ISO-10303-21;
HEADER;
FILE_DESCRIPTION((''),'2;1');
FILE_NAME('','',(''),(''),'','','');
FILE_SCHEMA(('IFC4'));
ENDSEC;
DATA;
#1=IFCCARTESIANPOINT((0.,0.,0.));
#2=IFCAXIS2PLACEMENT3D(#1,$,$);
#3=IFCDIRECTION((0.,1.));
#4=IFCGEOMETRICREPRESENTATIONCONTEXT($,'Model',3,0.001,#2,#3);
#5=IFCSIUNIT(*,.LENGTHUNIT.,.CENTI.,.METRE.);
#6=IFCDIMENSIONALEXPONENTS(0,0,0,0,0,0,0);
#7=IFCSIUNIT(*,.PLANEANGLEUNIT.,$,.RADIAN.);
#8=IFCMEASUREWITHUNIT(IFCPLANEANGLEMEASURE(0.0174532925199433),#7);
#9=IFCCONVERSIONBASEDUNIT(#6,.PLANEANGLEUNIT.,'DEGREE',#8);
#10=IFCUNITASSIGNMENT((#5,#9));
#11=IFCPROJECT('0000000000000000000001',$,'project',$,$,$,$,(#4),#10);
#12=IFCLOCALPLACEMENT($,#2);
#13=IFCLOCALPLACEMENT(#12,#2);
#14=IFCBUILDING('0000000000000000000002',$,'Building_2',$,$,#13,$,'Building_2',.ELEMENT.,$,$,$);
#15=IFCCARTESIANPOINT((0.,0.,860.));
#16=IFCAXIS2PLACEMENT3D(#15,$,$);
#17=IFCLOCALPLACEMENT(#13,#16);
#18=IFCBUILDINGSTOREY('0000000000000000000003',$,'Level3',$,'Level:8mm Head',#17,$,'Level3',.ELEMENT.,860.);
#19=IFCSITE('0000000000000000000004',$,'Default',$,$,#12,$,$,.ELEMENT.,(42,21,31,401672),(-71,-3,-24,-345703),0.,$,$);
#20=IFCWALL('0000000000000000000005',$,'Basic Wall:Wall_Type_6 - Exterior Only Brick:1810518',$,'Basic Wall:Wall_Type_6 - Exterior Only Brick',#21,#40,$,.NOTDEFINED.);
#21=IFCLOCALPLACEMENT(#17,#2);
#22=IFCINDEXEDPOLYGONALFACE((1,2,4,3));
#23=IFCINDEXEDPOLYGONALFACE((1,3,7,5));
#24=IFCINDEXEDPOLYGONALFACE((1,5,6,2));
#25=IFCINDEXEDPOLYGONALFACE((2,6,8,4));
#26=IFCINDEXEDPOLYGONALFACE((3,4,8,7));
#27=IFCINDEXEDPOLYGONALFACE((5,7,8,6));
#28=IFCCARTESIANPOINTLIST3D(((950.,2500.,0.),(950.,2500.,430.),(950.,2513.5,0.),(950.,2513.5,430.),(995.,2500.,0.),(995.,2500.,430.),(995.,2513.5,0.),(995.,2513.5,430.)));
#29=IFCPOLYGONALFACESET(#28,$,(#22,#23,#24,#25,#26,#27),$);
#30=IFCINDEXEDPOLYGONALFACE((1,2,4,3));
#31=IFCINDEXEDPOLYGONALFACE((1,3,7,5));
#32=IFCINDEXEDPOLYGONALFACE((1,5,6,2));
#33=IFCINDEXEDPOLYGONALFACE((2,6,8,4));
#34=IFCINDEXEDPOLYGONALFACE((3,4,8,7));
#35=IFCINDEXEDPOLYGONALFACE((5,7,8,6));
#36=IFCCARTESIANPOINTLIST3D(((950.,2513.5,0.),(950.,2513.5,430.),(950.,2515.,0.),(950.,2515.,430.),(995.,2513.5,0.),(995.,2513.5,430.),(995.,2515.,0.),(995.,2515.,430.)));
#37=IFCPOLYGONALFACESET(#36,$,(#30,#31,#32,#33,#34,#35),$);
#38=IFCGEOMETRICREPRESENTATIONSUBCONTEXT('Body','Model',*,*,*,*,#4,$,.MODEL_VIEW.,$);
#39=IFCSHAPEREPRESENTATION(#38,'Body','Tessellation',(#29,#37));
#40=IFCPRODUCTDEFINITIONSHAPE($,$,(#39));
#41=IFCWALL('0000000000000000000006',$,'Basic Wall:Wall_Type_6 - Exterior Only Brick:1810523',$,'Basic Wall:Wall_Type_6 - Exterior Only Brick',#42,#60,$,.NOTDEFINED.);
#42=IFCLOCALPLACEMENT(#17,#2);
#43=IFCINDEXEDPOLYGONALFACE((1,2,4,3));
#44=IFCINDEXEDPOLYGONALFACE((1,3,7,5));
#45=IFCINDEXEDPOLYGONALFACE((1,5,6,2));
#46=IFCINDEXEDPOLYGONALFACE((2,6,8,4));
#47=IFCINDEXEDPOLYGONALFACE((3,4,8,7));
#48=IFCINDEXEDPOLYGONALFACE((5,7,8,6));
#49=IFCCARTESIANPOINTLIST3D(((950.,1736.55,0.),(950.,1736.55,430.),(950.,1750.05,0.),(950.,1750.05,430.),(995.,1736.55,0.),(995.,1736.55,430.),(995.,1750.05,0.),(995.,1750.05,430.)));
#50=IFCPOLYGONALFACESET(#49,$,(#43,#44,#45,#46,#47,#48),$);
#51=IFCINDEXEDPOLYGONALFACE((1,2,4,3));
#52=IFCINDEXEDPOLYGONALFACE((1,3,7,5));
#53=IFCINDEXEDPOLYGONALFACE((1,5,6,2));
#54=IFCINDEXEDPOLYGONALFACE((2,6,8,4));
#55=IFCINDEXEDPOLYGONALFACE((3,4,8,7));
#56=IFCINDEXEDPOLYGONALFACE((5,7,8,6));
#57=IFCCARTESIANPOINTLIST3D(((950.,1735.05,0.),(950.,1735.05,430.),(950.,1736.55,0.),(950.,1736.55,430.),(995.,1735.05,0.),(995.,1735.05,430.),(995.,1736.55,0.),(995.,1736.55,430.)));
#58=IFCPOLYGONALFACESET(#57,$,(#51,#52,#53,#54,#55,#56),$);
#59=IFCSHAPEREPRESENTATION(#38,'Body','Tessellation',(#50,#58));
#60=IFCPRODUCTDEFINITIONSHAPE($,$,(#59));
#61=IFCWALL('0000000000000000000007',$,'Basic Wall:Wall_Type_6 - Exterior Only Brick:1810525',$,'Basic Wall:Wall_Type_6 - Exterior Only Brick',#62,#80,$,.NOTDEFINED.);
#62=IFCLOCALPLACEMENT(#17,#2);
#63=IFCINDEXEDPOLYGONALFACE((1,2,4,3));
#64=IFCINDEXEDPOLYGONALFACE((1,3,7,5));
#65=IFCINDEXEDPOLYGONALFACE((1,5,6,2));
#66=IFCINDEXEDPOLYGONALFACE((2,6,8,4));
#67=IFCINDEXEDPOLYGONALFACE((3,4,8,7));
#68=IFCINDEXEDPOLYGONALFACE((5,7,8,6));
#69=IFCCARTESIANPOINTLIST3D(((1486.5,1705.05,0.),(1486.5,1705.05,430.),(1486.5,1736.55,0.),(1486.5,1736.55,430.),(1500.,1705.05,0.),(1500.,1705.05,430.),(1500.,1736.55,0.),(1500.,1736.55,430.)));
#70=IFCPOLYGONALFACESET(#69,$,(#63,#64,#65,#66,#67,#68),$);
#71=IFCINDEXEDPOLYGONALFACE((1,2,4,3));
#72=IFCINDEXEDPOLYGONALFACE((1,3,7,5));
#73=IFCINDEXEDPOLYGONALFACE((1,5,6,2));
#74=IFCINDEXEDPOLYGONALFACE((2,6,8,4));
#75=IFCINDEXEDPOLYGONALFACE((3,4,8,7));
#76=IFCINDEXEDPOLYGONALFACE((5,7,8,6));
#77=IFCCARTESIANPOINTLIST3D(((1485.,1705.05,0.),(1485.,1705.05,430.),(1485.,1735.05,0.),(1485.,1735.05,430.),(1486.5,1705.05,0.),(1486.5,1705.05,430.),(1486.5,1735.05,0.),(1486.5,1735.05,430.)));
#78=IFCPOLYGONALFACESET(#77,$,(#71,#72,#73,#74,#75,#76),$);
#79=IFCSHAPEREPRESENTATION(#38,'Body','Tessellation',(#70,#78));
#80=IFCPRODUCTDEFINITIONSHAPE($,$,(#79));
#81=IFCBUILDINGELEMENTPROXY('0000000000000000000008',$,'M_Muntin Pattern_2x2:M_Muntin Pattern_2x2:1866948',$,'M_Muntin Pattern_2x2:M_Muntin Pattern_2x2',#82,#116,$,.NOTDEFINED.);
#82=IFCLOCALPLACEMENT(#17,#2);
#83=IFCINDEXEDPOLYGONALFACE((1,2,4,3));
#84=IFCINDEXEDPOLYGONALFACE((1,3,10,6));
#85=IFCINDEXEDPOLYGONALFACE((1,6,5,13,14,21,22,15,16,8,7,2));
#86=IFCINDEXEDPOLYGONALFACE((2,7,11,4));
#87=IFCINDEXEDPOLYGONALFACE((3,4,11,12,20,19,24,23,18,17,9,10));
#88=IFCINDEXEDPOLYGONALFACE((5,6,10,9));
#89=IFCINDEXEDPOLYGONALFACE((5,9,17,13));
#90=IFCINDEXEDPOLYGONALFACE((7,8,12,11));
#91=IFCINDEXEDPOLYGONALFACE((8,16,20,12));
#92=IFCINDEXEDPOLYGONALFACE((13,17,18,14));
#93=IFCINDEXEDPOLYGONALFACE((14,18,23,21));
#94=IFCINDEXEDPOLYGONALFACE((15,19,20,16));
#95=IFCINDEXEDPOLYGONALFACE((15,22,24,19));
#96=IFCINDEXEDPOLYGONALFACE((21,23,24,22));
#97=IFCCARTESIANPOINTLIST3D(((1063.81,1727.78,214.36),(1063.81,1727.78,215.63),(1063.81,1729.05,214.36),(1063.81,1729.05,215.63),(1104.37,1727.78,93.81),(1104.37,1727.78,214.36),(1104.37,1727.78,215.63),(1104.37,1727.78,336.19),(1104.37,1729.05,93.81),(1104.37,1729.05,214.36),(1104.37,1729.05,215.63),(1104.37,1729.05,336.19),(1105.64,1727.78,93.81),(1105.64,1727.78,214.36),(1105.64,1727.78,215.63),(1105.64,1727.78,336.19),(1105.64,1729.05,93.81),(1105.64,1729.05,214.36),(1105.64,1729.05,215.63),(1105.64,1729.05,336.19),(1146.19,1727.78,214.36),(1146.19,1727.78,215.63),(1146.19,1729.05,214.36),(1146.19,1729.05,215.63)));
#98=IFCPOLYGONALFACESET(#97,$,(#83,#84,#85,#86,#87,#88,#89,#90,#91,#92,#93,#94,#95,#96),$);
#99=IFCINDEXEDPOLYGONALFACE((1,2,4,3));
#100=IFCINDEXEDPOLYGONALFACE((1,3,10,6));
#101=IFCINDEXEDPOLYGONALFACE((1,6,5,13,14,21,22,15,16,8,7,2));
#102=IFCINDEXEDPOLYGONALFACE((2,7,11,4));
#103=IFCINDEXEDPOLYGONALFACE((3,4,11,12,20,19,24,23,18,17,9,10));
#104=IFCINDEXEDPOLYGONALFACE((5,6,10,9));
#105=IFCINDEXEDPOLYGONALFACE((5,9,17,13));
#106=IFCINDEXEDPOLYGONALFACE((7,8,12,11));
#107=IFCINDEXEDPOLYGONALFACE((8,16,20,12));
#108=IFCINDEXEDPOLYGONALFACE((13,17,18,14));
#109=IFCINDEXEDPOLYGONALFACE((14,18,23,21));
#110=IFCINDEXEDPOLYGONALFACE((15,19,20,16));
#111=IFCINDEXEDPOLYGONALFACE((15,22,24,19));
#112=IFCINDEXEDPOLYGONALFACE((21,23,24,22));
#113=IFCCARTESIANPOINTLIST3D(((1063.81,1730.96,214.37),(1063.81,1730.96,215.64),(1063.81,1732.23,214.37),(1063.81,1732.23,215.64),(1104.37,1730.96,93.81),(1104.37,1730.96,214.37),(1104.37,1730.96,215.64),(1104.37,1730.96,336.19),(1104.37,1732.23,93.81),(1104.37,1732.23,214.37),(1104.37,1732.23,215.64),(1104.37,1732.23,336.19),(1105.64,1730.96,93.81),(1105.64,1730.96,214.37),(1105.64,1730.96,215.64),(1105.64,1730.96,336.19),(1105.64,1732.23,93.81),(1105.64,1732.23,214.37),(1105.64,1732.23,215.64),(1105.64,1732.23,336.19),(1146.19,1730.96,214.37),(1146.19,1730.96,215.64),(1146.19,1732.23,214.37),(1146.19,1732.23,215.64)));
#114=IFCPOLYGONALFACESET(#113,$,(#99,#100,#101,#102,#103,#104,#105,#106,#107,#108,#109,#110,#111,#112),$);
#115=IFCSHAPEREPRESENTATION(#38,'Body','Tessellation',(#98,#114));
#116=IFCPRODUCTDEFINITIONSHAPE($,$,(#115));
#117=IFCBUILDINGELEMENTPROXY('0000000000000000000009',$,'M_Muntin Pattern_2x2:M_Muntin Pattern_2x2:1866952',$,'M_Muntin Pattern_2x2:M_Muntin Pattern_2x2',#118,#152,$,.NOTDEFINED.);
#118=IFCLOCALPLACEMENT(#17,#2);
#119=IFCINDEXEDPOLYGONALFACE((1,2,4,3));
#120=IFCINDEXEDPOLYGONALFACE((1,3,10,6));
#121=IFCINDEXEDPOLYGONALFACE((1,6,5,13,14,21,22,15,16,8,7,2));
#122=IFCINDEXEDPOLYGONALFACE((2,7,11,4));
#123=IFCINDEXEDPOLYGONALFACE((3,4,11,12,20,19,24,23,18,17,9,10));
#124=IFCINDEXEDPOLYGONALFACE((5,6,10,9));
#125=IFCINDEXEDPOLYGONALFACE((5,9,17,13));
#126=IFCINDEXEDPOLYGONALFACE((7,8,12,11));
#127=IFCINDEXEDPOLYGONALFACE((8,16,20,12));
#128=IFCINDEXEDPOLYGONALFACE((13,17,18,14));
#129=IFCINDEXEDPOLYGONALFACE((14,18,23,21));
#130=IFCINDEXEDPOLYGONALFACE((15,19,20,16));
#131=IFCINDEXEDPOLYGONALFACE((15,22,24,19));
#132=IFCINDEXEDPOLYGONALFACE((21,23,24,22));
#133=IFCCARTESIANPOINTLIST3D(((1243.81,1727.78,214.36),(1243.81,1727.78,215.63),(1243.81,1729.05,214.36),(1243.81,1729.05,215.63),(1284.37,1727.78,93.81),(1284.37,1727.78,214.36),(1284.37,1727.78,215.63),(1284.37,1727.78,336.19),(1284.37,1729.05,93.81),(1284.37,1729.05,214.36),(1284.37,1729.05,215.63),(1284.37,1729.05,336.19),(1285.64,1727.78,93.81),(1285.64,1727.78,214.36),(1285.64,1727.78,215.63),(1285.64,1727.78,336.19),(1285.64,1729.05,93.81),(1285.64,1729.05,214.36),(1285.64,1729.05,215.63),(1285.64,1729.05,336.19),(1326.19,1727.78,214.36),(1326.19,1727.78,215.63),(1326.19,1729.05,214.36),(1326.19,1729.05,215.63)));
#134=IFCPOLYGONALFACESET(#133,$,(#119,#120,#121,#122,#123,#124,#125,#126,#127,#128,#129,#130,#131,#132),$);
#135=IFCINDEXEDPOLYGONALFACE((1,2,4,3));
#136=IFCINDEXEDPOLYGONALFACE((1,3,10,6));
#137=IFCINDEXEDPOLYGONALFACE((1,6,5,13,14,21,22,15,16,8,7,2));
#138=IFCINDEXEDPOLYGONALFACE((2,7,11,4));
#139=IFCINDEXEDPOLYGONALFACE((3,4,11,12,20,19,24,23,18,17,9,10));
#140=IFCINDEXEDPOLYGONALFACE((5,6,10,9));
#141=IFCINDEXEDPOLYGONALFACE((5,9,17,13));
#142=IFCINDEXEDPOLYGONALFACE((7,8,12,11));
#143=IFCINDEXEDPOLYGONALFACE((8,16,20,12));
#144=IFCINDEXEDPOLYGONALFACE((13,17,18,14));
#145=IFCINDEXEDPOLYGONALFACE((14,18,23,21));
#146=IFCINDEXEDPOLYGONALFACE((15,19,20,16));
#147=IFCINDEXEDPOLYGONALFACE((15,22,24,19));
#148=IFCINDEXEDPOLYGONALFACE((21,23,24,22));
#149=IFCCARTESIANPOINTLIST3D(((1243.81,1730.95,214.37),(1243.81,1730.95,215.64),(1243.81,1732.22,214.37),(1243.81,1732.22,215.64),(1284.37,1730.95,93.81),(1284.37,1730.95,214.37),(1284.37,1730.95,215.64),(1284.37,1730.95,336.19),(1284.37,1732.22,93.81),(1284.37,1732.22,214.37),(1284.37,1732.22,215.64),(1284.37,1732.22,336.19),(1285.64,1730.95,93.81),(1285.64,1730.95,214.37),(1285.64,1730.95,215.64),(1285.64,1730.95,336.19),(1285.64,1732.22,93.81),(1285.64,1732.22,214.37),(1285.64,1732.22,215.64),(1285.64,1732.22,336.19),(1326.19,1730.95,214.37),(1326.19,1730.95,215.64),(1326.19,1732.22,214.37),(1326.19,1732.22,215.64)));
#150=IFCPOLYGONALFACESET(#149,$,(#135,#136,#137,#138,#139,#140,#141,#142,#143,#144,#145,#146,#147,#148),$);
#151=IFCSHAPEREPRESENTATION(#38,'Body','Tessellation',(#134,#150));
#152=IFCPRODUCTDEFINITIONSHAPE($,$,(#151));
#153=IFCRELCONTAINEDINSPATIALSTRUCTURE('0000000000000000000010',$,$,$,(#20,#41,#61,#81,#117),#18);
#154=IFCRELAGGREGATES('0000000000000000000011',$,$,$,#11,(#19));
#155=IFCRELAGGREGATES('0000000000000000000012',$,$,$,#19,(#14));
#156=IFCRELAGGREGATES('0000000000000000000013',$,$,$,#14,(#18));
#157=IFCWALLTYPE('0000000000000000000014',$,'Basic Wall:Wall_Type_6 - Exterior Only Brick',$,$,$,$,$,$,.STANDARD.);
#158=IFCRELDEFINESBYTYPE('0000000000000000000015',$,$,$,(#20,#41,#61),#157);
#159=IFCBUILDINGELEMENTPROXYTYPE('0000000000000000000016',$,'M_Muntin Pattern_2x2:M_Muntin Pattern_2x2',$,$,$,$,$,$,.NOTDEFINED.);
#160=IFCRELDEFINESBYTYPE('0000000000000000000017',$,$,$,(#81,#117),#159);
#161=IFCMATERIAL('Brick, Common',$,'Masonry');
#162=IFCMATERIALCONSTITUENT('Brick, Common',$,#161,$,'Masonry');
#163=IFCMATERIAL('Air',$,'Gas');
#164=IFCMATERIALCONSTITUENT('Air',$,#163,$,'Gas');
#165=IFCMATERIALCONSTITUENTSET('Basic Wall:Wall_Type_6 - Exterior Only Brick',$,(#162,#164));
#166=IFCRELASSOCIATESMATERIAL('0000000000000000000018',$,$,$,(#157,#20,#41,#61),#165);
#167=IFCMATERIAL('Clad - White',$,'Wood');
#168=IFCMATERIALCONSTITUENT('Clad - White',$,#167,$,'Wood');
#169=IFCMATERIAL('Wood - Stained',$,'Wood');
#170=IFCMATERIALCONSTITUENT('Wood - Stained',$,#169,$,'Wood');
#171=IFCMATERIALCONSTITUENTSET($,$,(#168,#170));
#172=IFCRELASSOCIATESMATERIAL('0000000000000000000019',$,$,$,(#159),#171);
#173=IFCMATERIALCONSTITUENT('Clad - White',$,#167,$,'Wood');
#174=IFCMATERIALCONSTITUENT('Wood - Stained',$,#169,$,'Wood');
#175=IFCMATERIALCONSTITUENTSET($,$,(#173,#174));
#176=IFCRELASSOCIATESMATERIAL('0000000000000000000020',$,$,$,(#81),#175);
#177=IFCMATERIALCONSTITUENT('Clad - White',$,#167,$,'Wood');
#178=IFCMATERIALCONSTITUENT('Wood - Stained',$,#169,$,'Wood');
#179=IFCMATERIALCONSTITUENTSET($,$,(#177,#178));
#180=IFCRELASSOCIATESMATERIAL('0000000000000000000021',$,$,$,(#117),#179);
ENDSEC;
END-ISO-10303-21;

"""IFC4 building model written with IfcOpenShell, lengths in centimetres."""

from ifc_helpers import new_model, entity, si_unit, converted_unit, direction, frame, origin, place, context, subcontext, project, spatial, indexed_curve, outline, extrude, source, transform, mapped, material, constituent, constituent_set, type_object, type_shapes, element, save


model = new_model("IFC4")

# Units and contexts
model_context = context("Model", 3, precision=0.001, world=origin(), true_north=direction((0.0, 1.0)))
body_context = subcontext(model_context, "Body", "Model", "MODEL_VIEW")
ifc_project = project(units=[si_unit("LENGTHUNIT", "METRE", prefix="CENTI"), converted_unit("PLANEANGLEUNIT", "DEGREE", entity("IfcPlaneAngleMeasure", 0.0174532925199433), si_unit("PLANEANGLEUNIT", "RADIAN"), dimensions=[0, 0, 0, 0, 0, 0, 0])], contexts=[model_context])

# Site, building, storey
site_placement = place(None, origin())
site = spatial("IfcSite", under=ifc_project, at=site_placement, Name="Default", CompositionType="ELEMENT", RefLatitude=(42, 21, 31, 401672), RefLongitude=(-71, -3, -24, -345703), RefElevation=0.0)
building_placement = place(site_placement, origin())
building = spatial("IfcBuilding", under=site, at=building_placement, Name="Building_2", LongName="Building_2", CompositionType="ELEMENT")
storey_placement = place(building_placement, frame((0.0, 0.0, 860.0)))
storey = spatial("IfcBuildingStorey", under=building, at=storey_placement, Name="Level3", ObjectType="Level:8mm Head", LongName="Level3", CompositionType="ELEMENT", Elevation=860.0)

# Shared definitions
ifc_material_1 = material(Name="Brick, Common", Category="Masonry")
ifc_material_2 = material(Name="Air", Category="Gas")

# Walls
ifc_constituent_1 = constituent(ifc_material_1, Name="Brick, Common", Category="Masonry")
ifc_constituent_2 = constituent(ifc_material_2, Name="Air", Category="Gas")
ifc_constituent_set_1 = constituent_set(constituents=[ifc_constituent_1, ifc_constituent_2], Name="Basic Wall:Wall_Type_6 - Exterior Only Brick")
wall_type_1 = type_object("IfcWallType", Name="Basic Wall:Wall_Type_6 - Exterior Only Brick", PredefinedType="STANDARD", material=ifc_constituent_set_1)
wall_1_placement = place(storey_placement, frame((995.0, 2507.5, 0.0), z_axis=(0.0, 0.0, 1.0), x_axis=(-1.0, 0.0, 0.0)))
element("IfcWall", 1, at=wall_1_placement, inside=storey, type_object=wall_type_1, material=ifc_constituent_set_1, Name="Basic Wall:Wall_Type_6 - Exterior Only Brick:1810518", ObjectType="Basic Wall:Wall_Type_6 - Exterior Only Brick", PredefinedType="NOTDEFINED", context=body_context, shape_type="SweptSolid", body=[
    extrude(outline(indexed_curve([(-6.75, -22.5), (6.75, -22.5), (6.75, 22.5), (-6.75, 22.5), (-6.75, -22.5)], self_intersect=False)), frame((22.5, 0.75, 0.0), z_axis=(0.0, 0.0, 1.0), x_axis=(0.0, -1.0, 0.0)), (0.0, 0.0, 1.0), 430.0),
    extrude(outline(indexed_curve([(-0.75, -22.5), (0.75, -22.5), (0.75, 22.5), (-0.75, 22.5), (-0.75, -22.5)], self_intersect=False)), frame((22.5, -6.75, 0.0), z_axis=(0.0, 0.0, 1.0), x_axis=(0.0, 1.0, 0.0)), (0.0, 0.0, 1.0), 430.0),
])
wall_2_placement = place(storey_placement, frame((950.0, 1742.55, 0.0)))
element("IfcWall", 2, at=wall_2_placement, inside=storey, type_object=wall_type_1, material=ifc_constituent_set_1, Name="Basic Wall:Wall_Type_6 - Exterior Only Brick:1810523", ObjectType="Basic Wall:Wall_Type_6 - Exterior Only Brick", PredefinedType="NOTDEFINED", context=body_context, shape_type="SweptSolid", body=[
    extrude(outline(indexed_curve([(-6.75, -22.5), (6.75, -22.5), (6.75, 22.5), (-6.75, 22.5), (-6.75, -22.5)], self_intersect=False)), frame((22.5, 0.75, 0.0), z_axis=(0.0, 0.0, 1.0), x_axis=(0.0, -1.0, 0.0)), (0.0, 0.0, 1.0), 430.0),
    extrude(outline(indexed_curve([(-0.75, -22.5), (0.75, -22.5), (0.75, 22.5), (-0.75, 22.5), (-0.75, -22.5)], self_intersect=False)), frame((22.5, -6.75, 0.0), z_axis=(0.0, 0.0, 1.0), x_axis=(0.0, 1.0, 0.0)), (0.0, 0.0, 1.0), 430.0),
])
wall_3_placement = place(storey_placement, frame((1492.5, 1735.05, 0.0), z_axis=(0.0, 0.0, 1.0), x_axis=(0.0, -1.0, 0.0)))
element("IfcWall", 3, at=wall_3_placement, inside=storey, type_object=wall_type_1, material=ifc_constituent_set_1, Name="Basic Wall:Wall_Type_6 - Exterior Only Brick:1810525", ObjectType="Basic Wall:Wall_Type_6 - Exterior Only Brick", PredefinedType="NOTDEFINED", context=body_context, shape_type="SweptSolid", body=[
    extrude(outline(indexed_curve([(-6.75, -15.75), (6.75, -15.75), (6.75, 15.75), (-6.75, 15.75), (-6.75, -15.75)], self_intersect=False)), frame((14.25, 0.75, 0.0), z_axis=(0.0, 0.0, 1.0), x_axis=(0.0, -1.0, 0.0)), (0.0, 0.0, 1.0), 430.0),
    extrude(outline(indexed_curve([(-0.75, -15.0), (0.75, -15.0), (0.75, 15.0), (-0.75, 15.0), (-0.75, -15.0)], self_intersect=False)), frame((15.0, -6.75, 0.0), z_axis=(0.0, 0.0, 1.0), x_axis=(0.0, 1.0, 0.0)), (0.0, 0.0, 1.0), 430.0),
])

# Building element proxies
ifc_material_3 = material(Name="Clad - White", Category="Wood")
ifc_constituent_3 = constituent(ifc_material_3, Name="Clad - White", Category="Wood")
ifc_material_4 = material(Name="Wood - Stained", Category="Wood")
ifc_constituent_4 = constituent(ifc_material_4, Name="Wood - Stained", Category="Wood")
ifc_constituent_set_2 = constituent_set(constituents=[ifc_constituent_3, ifc_constituent_4])
ifc_constituent_5 = constituent(ifc_material_3, Name="Clad - White", Category="Wood")
ifc_constituent_6 = constituent(ifc_material_4, Name="Wood - Stained", Category="Wood")
ifc_constituent_set_3 = constituent_set(constituents=[ifc_constituent_5, ifc_constituent_6])
building_element_proxy_type_1 = type_object("IfcBuildingElementProxyType", Name="M_Muntin Pattern_2x2:M_Muntin Pattern_2x2", PredefinedType="NOTDEFINED", material=ifc_constituent_set_3)
shared_shape_1 = source(origin(), body_context, "Body", "SweptSolid", [
    extrude(outline(indexed_curve([(0.64, -0.64), (121.19, -0.64), (121.19, 0.63), (0.64, 0.63), (0.64, 41.19), (-0.63, 41.19), (-0.63, 0.63), (-121.19, 0.63), (-121.19, -0.64), (-0.63, -0.64), (-0.63, -41.19), (0.64, -41.19), (0.64, -0.64)], self_intersect=False)), frame((0.0, 0.95, 121.19), z_axis=(0.0, 1.0, 0.0), x_axis=(0.0, 0.0, 1.0)), (0.0, 0.0, 1.0), 1.27),
    extrude(outline(indexed_curve([(0.64, -0.64), (121.19, -0.64), (121.19, 0.63), (0.64, 0.63), (0.64, 41.19), (-0.63, 41.19), (-0.63, 0.63), (-121.19, 0.63), (-121.19, -0.64), (-0.63, -0.64), (-0.63, -41.19), (0.64, -41.19), (0.64, -0.64)], self_intersect=False)), frame((0.0, -2.22, 121.19), z_axis=(0.0, 1.0, 0.0), x_axis=(0.0, 0.0, 1.0)), (0.0, 0.0, 1.0), 1.27),
])
type_shapes(building_element_proxy_type_1, [shared_shape_1])
proxy_1_placement = place(storey_placement, frame((1105.0, 1730.0, 93.81), z_axis=(0.0, 0.0, 1.0), x_axis=(-1.0, 0.0, 0.0)))
element("IfcBuildingElementProxy", 4, at=proxy_1_placement, inside=storey, type_object=building_element_proxy_type_1, material=ifc_constituent_set_2, Name="M_Muntin Pattern_2x2:M_Muntin Pattern_2x2:1866948", ObjectType="M_Muntin Pattern_2x2:M_Muntin Pattern_2x2", PredefinedType="NOTDEFINED", context=body_context, shape_type="MappedRepresentation", body=[
    mapped(shared_shape_1, transform((0.0, 0.0, 0.0), scale=1.0)),
])
ifc_constituent_7 = constituent(ifc_material_3, Name="Clad - White", Category="Wood")
ifc_constituent_8 = constituent(ifc_material_4, Name="Wood - Stained", Category="Wood")
ifc_constituent_set_4 = constituent_set(constituents=[ifc_constituent_7, ifc_constituent_8])
proxy_2_placement = place(storey_placement, frame((1285.0, 1730.0, 93.81), z_axis=(0.0, 0.0, 1.0), x_axis=(-1.0, 0.0, 0.0)))
element("IfcBuildingElementProxy", 5, at=proxy_2_placement, inside=storey, type_object=building_element_proxy_type_1, material=ifc_constituent_set_4, Name="M_Muntin Pattern_2x2:M_Muntin Pattern_2x2:1866952", ObjectType="M_Muntin Pattern_2x2:M_Muntin Pattern_2x2", PredefinedType="NOTDEFINED", context=body_context, shape_type="MappedRepresentation", body=[
    mapped(shared_shape_1, transform((0.0, 0.0, 0.0), scale=1.0)),
])

save(model, "model.ifc")
